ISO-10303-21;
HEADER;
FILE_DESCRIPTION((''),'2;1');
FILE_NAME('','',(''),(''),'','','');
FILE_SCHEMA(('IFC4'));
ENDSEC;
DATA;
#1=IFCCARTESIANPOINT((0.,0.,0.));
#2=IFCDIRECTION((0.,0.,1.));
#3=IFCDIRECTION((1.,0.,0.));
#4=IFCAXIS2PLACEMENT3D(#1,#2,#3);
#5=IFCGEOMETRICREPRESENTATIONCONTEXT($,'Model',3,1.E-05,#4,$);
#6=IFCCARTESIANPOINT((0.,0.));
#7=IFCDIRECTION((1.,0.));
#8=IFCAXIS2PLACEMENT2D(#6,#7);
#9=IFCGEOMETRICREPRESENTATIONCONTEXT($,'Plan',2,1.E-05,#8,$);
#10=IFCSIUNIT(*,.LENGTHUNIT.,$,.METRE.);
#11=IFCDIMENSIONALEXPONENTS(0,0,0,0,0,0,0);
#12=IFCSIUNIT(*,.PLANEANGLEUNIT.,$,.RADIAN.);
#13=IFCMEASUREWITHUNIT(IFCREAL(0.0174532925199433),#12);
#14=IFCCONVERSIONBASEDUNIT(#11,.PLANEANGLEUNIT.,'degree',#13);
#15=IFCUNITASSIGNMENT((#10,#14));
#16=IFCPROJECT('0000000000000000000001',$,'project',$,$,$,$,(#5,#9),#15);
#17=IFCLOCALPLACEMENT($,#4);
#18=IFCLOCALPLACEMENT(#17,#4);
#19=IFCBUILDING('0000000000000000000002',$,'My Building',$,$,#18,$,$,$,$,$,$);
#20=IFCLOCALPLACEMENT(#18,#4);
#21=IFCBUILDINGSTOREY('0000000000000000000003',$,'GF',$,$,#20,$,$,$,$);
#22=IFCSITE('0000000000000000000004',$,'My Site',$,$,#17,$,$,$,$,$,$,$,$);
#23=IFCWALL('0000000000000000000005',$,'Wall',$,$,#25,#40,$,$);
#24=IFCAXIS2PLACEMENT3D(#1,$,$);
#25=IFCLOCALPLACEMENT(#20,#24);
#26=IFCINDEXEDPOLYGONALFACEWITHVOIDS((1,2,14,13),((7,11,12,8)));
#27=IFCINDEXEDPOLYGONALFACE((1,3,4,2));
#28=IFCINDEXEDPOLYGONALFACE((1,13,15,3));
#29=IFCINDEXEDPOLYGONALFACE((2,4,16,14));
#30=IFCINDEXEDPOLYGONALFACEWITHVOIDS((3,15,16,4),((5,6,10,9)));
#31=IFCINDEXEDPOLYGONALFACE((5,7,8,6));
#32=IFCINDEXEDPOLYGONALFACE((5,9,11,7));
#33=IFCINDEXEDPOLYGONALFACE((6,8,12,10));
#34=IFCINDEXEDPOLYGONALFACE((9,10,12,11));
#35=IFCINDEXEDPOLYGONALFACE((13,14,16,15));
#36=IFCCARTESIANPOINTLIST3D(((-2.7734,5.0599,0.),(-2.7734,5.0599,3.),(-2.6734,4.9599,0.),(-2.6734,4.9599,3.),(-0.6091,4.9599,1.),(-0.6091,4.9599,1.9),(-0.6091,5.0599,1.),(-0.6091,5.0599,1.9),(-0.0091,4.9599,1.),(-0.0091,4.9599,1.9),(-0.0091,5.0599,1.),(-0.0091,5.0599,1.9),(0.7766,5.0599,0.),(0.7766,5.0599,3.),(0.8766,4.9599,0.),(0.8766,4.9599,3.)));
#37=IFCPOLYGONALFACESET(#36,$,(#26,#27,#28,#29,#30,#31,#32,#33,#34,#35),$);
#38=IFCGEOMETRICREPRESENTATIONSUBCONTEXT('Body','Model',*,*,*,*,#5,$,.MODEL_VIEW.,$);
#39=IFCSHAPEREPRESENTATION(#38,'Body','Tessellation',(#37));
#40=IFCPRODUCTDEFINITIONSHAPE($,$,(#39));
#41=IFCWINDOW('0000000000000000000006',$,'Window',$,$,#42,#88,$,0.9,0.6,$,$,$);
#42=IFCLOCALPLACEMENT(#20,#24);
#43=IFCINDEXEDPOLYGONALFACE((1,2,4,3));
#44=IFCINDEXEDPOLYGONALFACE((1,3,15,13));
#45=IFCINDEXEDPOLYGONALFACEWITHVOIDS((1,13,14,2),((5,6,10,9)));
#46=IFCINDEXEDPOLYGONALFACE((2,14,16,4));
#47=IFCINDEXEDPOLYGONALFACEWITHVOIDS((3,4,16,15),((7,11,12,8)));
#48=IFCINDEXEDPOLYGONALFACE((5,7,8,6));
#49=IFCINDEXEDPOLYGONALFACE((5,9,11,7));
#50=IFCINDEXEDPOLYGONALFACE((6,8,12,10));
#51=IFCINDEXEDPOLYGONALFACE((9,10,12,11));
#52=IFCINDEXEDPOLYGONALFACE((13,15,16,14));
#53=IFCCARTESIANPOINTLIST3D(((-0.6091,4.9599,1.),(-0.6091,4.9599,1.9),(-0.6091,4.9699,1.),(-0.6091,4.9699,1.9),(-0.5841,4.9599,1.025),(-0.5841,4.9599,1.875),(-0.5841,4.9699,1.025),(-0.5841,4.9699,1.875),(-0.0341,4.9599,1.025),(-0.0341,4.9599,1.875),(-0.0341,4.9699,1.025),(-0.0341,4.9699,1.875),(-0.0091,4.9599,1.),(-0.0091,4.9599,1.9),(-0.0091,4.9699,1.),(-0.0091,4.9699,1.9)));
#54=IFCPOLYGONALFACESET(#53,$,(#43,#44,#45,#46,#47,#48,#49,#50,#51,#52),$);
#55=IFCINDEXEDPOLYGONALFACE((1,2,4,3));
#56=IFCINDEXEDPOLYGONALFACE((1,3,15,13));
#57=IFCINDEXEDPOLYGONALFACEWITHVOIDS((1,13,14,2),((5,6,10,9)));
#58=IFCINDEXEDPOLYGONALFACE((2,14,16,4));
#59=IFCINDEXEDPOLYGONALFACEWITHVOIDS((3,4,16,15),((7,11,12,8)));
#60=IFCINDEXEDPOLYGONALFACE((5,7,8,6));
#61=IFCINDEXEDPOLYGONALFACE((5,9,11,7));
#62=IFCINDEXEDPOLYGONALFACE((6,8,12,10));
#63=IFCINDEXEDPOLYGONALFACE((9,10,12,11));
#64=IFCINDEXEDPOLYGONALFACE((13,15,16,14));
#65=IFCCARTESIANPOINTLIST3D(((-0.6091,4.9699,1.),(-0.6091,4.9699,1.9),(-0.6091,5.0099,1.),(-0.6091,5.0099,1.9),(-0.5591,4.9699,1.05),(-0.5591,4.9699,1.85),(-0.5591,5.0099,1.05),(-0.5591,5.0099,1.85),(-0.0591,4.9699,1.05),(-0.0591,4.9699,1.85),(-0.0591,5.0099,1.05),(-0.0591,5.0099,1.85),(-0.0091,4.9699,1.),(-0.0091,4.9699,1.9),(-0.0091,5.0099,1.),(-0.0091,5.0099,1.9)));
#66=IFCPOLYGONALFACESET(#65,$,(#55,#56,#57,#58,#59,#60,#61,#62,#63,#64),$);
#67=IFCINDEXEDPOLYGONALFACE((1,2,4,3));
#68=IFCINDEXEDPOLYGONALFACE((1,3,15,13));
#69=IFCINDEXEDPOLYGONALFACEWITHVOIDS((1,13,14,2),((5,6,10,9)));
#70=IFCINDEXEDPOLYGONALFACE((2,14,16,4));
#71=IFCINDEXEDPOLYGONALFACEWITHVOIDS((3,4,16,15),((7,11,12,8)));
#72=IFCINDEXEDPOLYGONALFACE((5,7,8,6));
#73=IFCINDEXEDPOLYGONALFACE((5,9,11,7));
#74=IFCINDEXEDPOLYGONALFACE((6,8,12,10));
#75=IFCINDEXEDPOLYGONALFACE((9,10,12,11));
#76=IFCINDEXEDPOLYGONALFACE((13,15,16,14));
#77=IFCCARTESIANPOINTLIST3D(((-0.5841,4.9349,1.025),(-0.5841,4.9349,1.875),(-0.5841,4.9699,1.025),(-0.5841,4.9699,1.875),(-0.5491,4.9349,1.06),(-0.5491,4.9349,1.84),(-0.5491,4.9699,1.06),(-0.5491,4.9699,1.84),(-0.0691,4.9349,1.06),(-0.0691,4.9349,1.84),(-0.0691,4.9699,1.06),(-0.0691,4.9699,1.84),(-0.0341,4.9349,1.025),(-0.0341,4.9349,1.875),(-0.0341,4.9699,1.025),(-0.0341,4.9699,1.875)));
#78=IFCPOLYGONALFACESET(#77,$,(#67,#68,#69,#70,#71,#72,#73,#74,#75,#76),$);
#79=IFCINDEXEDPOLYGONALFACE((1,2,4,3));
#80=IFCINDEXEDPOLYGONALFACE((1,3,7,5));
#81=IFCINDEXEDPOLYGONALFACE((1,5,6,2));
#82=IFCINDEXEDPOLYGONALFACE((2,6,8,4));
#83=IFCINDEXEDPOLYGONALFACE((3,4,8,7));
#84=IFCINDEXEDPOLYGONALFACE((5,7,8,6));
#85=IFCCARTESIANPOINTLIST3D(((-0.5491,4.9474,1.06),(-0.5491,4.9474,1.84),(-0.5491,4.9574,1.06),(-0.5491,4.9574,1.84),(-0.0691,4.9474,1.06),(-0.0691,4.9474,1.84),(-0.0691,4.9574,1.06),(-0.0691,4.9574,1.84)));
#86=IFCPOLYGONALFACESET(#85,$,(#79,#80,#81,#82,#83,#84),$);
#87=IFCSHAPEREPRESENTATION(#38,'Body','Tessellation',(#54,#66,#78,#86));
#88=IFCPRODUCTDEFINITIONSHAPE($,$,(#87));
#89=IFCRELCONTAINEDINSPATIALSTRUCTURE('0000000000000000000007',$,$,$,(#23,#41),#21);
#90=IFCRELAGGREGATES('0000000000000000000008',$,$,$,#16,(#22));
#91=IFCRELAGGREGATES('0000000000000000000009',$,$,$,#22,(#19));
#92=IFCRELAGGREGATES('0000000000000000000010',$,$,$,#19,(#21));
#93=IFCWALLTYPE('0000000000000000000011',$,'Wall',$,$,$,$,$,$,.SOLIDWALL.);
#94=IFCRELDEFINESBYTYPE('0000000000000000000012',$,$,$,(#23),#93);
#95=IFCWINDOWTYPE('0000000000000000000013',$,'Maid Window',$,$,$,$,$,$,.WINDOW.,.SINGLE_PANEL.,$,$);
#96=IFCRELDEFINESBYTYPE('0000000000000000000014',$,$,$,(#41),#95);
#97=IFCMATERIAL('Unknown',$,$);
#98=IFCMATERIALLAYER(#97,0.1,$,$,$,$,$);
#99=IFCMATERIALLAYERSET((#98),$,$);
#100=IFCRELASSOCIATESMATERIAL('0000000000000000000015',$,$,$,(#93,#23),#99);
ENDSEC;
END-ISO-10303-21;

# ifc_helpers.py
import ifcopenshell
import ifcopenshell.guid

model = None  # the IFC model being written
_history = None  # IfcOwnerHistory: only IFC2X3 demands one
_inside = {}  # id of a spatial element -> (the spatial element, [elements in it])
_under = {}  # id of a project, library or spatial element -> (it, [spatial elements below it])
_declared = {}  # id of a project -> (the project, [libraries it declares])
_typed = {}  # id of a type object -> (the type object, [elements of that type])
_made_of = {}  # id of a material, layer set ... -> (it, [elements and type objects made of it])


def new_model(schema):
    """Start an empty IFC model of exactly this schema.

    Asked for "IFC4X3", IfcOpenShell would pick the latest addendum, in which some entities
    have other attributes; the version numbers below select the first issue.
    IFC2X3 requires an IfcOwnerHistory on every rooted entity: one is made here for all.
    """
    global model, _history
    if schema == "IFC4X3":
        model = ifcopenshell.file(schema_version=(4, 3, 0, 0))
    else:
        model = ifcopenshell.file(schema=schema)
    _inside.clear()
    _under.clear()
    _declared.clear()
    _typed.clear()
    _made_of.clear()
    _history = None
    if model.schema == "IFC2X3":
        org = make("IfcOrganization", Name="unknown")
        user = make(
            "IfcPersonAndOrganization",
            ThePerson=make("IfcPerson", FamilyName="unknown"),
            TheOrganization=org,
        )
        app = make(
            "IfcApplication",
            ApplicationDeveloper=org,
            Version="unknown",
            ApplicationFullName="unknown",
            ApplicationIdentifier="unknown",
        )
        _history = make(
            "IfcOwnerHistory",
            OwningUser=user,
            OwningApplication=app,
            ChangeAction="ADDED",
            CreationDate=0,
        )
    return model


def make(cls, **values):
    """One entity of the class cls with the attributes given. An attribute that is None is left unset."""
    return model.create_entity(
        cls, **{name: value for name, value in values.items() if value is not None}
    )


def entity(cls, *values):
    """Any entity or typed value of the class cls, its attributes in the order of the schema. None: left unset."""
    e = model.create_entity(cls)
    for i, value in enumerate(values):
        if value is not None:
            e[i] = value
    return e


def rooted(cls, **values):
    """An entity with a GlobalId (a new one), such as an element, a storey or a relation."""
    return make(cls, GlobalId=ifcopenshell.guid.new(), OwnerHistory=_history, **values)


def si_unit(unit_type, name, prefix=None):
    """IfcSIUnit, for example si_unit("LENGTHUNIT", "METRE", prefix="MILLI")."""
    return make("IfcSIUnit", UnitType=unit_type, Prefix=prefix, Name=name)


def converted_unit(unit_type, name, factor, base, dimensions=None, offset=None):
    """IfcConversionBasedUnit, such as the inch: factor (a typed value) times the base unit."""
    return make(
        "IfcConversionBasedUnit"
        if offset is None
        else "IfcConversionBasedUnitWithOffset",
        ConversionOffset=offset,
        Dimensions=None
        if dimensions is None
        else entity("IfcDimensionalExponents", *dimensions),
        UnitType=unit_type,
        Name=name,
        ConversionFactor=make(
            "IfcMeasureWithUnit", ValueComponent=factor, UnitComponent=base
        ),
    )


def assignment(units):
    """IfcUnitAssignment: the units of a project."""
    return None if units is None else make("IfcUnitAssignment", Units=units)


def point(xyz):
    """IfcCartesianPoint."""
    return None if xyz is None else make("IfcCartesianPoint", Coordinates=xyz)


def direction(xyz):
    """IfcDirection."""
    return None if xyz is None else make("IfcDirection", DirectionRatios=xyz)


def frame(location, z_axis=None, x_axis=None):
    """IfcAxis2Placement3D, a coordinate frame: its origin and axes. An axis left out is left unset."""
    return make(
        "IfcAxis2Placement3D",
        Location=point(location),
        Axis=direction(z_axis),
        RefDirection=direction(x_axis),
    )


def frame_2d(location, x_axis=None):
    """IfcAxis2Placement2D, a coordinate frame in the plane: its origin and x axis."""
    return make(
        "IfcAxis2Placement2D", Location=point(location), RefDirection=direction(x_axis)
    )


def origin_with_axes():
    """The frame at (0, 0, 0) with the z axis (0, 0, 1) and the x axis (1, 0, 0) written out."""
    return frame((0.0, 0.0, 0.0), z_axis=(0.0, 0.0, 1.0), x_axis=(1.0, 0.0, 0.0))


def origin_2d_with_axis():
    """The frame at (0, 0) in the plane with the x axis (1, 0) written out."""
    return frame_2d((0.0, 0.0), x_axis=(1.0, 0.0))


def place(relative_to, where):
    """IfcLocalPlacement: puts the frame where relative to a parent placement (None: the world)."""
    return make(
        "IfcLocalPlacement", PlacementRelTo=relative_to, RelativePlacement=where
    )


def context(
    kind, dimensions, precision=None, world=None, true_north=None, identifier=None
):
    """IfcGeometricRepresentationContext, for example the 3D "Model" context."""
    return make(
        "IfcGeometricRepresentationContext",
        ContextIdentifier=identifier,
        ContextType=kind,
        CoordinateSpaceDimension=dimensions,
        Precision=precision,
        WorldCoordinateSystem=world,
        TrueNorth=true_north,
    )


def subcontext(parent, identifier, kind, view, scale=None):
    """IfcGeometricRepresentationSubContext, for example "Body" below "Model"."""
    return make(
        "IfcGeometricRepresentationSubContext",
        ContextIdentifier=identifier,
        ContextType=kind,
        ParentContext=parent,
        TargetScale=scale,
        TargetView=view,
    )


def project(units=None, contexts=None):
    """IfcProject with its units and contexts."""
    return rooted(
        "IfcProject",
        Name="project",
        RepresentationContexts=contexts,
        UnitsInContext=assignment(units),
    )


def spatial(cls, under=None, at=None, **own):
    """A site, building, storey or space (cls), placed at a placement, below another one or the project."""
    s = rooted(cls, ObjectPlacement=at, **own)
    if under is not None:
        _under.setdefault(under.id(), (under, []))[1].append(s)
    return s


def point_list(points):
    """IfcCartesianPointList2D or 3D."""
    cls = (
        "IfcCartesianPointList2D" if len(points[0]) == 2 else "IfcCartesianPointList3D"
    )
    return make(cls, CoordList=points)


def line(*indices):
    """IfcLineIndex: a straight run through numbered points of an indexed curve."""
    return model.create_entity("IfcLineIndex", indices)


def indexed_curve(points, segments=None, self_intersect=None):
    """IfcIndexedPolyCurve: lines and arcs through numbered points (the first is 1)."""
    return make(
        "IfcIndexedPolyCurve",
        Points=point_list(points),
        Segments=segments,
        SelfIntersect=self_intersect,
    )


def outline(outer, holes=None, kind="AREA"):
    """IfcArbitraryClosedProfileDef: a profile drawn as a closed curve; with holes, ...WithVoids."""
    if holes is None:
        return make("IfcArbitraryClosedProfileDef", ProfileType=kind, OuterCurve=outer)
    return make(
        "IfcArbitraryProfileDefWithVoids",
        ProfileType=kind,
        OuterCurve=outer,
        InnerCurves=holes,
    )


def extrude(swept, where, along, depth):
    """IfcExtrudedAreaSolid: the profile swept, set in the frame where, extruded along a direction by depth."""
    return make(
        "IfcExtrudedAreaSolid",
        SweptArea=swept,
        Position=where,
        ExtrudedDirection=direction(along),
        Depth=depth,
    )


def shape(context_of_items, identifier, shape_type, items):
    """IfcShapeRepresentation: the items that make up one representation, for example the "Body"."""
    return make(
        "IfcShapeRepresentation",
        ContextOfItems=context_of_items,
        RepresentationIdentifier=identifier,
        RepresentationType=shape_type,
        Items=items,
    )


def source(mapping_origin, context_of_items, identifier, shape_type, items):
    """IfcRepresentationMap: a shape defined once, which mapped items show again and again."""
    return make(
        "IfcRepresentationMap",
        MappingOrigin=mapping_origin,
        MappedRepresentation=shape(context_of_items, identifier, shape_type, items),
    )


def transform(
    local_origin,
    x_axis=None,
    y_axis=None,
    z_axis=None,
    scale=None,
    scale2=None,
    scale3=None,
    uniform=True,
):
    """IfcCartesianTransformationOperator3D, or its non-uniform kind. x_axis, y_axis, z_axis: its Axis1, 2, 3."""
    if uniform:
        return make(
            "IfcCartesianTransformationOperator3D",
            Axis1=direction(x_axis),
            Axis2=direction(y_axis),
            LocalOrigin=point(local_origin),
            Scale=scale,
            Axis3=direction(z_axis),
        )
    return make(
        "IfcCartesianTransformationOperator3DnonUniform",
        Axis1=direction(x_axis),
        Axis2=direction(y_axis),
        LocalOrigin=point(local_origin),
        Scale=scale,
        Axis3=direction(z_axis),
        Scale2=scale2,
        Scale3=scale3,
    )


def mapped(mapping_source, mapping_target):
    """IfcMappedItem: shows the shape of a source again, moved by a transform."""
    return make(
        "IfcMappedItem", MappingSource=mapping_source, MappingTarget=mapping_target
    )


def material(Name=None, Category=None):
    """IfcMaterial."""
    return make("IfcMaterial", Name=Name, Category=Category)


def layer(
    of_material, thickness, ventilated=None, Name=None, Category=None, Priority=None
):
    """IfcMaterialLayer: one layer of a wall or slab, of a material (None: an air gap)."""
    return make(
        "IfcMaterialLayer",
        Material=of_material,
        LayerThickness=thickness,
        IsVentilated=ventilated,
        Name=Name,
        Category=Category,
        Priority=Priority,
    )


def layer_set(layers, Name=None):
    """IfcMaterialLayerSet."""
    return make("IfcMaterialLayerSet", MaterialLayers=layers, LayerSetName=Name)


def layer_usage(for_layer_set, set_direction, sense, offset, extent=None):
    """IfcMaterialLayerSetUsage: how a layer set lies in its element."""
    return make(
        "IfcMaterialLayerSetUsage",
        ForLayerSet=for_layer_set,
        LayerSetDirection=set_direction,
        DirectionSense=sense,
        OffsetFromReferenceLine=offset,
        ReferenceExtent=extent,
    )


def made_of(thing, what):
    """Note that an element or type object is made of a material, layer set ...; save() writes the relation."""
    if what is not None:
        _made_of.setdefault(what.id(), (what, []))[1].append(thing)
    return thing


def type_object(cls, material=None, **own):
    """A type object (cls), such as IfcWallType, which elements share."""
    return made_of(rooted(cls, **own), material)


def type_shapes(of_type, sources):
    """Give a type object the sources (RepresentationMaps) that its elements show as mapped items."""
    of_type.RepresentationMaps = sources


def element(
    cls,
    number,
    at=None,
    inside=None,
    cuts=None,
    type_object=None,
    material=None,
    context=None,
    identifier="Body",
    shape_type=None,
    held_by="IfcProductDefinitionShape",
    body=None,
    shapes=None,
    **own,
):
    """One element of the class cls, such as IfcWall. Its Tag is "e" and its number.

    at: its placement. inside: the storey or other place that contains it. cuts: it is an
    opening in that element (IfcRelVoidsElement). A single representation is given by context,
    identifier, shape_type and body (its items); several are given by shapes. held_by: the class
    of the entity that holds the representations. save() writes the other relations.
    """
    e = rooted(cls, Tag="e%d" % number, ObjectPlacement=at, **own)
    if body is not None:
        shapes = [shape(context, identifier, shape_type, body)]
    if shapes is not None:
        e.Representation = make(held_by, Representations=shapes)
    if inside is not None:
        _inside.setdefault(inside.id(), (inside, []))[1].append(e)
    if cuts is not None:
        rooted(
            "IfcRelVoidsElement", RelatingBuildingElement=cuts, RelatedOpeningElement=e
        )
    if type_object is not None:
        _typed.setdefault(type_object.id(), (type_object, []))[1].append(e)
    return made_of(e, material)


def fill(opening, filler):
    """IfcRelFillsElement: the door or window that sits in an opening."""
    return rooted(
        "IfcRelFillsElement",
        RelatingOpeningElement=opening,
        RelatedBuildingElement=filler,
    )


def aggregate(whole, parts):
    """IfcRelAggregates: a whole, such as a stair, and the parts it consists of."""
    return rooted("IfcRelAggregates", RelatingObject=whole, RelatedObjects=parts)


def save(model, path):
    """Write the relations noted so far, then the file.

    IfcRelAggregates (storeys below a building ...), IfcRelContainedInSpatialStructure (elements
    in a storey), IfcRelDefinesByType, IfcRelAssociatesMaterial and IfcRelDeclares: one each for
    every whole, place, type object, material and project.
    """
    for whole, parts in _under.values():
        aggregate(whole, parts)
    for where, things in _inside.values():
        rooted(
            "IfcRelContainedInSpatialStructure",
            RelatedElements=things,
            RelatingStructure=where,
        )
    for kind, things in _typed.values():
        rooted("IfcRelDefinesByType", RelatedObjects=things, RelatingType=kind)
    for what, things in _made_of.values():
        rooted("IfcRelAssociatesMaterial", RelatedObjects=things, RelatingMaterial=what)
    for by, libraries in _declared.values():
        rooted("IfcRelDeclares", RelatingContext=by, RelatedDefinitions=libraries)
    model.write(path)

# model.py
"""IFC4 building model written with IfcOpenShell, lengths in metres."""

from ifc_helpers import new_model, entity, si_unit, converted_unit, frame, origin_with_axes, origin_2d_with_axis, place, context, subcontext, project, spatial, line, indexed_curve, outline, extrude, shape, source, transform, mapped, material, layer, layer_set, layer_usage, type_object, type_shapes, element, fill, save


model = new_model("IFC4")

# Units and contexts
model_context = context("Model", 3, precision=1e-05, world=origin_with_axes())
plan_context = context("Plan", 2, precision=1e-05, world=origin_2d_with_axis())
body_context_1 = subcontext(model_context, "Body", "Model", "MODEL_VIEW")
body_context_2 = subcontext(plan_context, "Body", "Plan", "PLAN_VIEW")
ifc_project = project(units=[si_unit("LENGTHUNIT", "METRE"), converted_unit("PLANEANGLEUNIT", "degree", entity("IfcReal", 0.0174532925199433), si_unit("PLANEANGLEUNIT", "RADIAN"), dimensions=[0, 0, 0, 0, 0, 0, 0])], contexts=[model_context, plan_context])

# Site, building, storey
site_placement = place(None, origin_with_axes())
site = spatial("IfcSite", under=ifc_project, at=site_placement, Name="My Site")
building_placement = place(site_placement, origin_with_axes())
building = spatial("IfcBuilding", under=site, at=building_placement, Name="My Building")
storey_placement = place(building_placement, origin_with_axes())
storey = spatial("IfcBuildingStorey", under=building, at=storey_placement, Name="GF")

# Shared definitions
ifc_material = material(Name="Unknown")

# Shared definitions
ifc_layer_1 = layer(ifc_material, 0.1)
ifc_layer_set_1 = layer_set([ifc_layer_1])
wall_type = type_object("IfcWallType", Name="Wall", PredefinedType="SOLIDWALL", material=ifc_layer_set_1)

# Wall, opening, window
ifc_layer_usage_1 = layer_usage(ifc_layer_set_1, "AXIS2", "POSITIVE", 0.0)
wall_1_placement = place(storey_placement, frame((0.7766, 5.0599, 0.0), z_axis=(0.0, 0.0, 1.0), x_axis=(-1.0, 0.0, 0.0)))
wall_1 = element("IfcWall", 1, at=wall_1_placement, inside=storey, type_object=wall_type, material=ifc_layer_usage_1, Name="Wall", context=body_context_1, shape_type="SweptSolid", body=[
    extrude(outline(indexed_curve([(0.0, 0.0), (-0.1, 0.1), (3.45, 0.1), (3.55, 0.0)], segments=[line(1, 2, 3, 4, 1)])), origin_with_axes(), (0.0, 0.0, 1.0), 3.0),
])
shared_shape_1 = source(origin_with_axes(), body_context_1, "Body", "SweptSolid", [
    extrude(outline(indexed_curve([(0.0, 0.0), (0.6, 0.0), (0.6, 0.9), (0.0, 0.9)], segments=[line(1, 2, 3, 4, 1)])), frame((0.0, -0.6, 0.0), z_axis=(0.0, -1.0, 0.0), x_axis=(1.0, 0.0, 0.0)), (0.0, 0.0, -1.0), 1.2),
])
opening_1_placement = place(wall_1_placement, frame((0.7857, 0.0, 1.0), z_axis=(0.0, 0.0, 1.0), x_axis=(1.0, 0.0, 0.0)))
opening_1 = element("IfcOpeningElement", 2, at=opening_1_placement, cuts=wall_1, PredefinedType="OPENING", context=body_context_1, shape_type="MappedRepresentation", body=[
    mapped(shared_shape_1, transform((0.0, 0.0, 0.0), x_axis=(1.0, 0.0, 0.0), y_axis=(0.0, 1.0, 0.0), z_axis=(0.0, 0.0, 1.0), scale=1.0)),
])
window_type_1 = type_object("IfcWindowType", Name="Maid Window", PartitioningType="SINGLE_PANEL", PredefinedType="WINDOW")
shared_shape_2 = source(origin_with_axes(), body_context_1, "Body", "SweptSolid", [
    extrude(outline(indexed_curve([(0.0, 0.0), (0.6, 0.0), (0.6, 0.9), (0.0, 0.9)], segments=[line(1, 2, 3, 4, 1)]), holes=[indexed_curve([(0.025, 0.025), (0.575, 0.025), (0.575, 0.875), (0.025, 0.875)], segments=[line(1, 2, 3, 4, 1)])]), frame((0.0, 0.09, 0.0), z_axis=(0.0, -1.0, 0.0), x_axis=(1.0, 0.0, 0.0)), (0.0, 0.0, -1.0), 0.01),
    extrude(outline(indexed_curve([(0.0, 0.0), (0.6, 0.0), (0.6, 0.9), (0.0, 0.9)], segments=[line(1, 2, 3, 4, 1)]), holes=[indexed_curve([(0.05, 0.05), (0.55, 0.05), (0.55, 0.85), (0.05, 0.85)], segments=[line(1, 2, 3, 4, 1)])]), frame((0.0, 0.05, 0.0), z_axis=(0.0, -1.0, 0.0), x_axis=(1.0, 0.0, 0.0)), (0.0, 0.0, -1.0), 0.04),
    extrude(outline(indexed_curve([(0.0, 0.0), (0.55, 0.0), (0.55, 0.85), (0.0, 0.85)], segments=[line(1, 2, 3, 4, 1)]), holes=[indexed_curve([(0.035, 0.035), (0.515, 0.035), (0.515, 0.815), (0.035, 0.815)], segments=[line(1, 2, 3, 4, 1)])]), frame((0.025, 0.09, 0.025), z_axis=(0.0, -1.0, 0.0), x_axis=(1.0, 0.0, 0.0)), (0.0, 0.0, -1.0), 0.035),
    extrude(outline(indexed_curve([(0.035, 0.035), (0.515, 0.035), (0.515, 0.815), (0.035, 0.815)], segments=[line(1, 2, 3, 4, 1)])), frame((0.025, 0.1025, 0.025), z_axis=(0.0, -1.0, 0.0), x_axis=(1.0, 0.0, 0.0)), (0.0, 0.0, -1.0), 0.01),
])
shared_shape_3 = source(origin_with_axes(), body_context_2, "Body", "Curve2D", [
    entity("IfcIndexedPolyCurve", entity("IfcCartesianPointList2D", [[0.05, 0.05], [0.55, 0.05]])),
    entity("IfcIndexedPolyCurve", entity("IfcCartesianPointList2D", [[0.0, 0.1], [0.025, 0.1], [0.025, 0.09], [0.05, 0.09], [0.05, 0.05], [0.0, 0.05]]), [entity("IfcLineIndex", [1, 2, 3, 4, 5, 6, 1])]),
    entity("IfcIndexedPolyCurve", entity("IfcCartesianPointList2D", [[0.6, 0.1], [0.575, 0.1], [0.575, 0.09], [0.55, 0.09], [0.55, 0.05], [0.6, 0.05]]), [entity("IfcLineIndex", [1, 2, 3, 4, 5, 6, 1])]),
    entity("IfcIndexedPolyCurve", entity("IfcCartesianPointList2D", [[0.025, 0.09], [0.06, 0.09], [0.06, 0.125], [0.025, 0.125]]), [entity("IfcLineIndex", [1, 2, 3, 4, 1])]),
    entity("IfcIndexedPolyCurve", entity("IfcCartesianPointList2D", [[0.575, 0.09], [0.54, 0.09], [0.54, 0.125], [0.575, 0.125]]), [entity("IfcLineIndex", [1, 2, 3, 4, 1])]),
    entity("IfcIndexedPolyCurve", entity("IfcCartesianPointList2D", [[0.06, 0.09], [0.54, 0.09]])),
    entity("IfcIndexedPolyCurve", entity("IfcCartesianPointList2D", [[0.06, 0.125], [0.54, 0.125]])),
    entity("IfcIndexedPolyCurve", entity("IfcCartesianPointList2D", [[0.06, 0.1075], [0.54, 0.1075]])),
])
type_shapes(window_type_1, [shared_shape_2, shared_shape_3])
window_1_placement = place(opening_1_placement, frame((0.0, 0.0, 0.0), z_axis=(0.0, 0.0, 1.0), x_axis=(1.0, 0.0, 0.0)))
window_1 = element("IfcWindow", 3, at=window_1_placement, inside=storey, type_object=window_type_1, Name="Window", OverallHeight=0.9, OverallWidth=0.6, shapes=[
    shape(body_context_1, "Body", "MappedRepresentation", [mapped(shared_shape_2, transform((0.0, 0.0, 0.0), x_axis=(1.0, 0.0, 0.0), y_axis=(0.0, 1.0, 0.0), z_axis=(0.0, 0.0, 1.0), scale=1.0))]),
    shape(body_context_2, "Body", "MappedRepresentation", [mapped(shared_shape_3, transform((0.0, 0.0, 0.0), x_axis=(1.0, 0.0, 0.0), y_axis=(0.0, 1.0, 0.0), z_axis=(0.0, 0.0, 1.0), scale=1.0))]),
])
fill(opening_1, window_1)

save(model, "model.ifc")
